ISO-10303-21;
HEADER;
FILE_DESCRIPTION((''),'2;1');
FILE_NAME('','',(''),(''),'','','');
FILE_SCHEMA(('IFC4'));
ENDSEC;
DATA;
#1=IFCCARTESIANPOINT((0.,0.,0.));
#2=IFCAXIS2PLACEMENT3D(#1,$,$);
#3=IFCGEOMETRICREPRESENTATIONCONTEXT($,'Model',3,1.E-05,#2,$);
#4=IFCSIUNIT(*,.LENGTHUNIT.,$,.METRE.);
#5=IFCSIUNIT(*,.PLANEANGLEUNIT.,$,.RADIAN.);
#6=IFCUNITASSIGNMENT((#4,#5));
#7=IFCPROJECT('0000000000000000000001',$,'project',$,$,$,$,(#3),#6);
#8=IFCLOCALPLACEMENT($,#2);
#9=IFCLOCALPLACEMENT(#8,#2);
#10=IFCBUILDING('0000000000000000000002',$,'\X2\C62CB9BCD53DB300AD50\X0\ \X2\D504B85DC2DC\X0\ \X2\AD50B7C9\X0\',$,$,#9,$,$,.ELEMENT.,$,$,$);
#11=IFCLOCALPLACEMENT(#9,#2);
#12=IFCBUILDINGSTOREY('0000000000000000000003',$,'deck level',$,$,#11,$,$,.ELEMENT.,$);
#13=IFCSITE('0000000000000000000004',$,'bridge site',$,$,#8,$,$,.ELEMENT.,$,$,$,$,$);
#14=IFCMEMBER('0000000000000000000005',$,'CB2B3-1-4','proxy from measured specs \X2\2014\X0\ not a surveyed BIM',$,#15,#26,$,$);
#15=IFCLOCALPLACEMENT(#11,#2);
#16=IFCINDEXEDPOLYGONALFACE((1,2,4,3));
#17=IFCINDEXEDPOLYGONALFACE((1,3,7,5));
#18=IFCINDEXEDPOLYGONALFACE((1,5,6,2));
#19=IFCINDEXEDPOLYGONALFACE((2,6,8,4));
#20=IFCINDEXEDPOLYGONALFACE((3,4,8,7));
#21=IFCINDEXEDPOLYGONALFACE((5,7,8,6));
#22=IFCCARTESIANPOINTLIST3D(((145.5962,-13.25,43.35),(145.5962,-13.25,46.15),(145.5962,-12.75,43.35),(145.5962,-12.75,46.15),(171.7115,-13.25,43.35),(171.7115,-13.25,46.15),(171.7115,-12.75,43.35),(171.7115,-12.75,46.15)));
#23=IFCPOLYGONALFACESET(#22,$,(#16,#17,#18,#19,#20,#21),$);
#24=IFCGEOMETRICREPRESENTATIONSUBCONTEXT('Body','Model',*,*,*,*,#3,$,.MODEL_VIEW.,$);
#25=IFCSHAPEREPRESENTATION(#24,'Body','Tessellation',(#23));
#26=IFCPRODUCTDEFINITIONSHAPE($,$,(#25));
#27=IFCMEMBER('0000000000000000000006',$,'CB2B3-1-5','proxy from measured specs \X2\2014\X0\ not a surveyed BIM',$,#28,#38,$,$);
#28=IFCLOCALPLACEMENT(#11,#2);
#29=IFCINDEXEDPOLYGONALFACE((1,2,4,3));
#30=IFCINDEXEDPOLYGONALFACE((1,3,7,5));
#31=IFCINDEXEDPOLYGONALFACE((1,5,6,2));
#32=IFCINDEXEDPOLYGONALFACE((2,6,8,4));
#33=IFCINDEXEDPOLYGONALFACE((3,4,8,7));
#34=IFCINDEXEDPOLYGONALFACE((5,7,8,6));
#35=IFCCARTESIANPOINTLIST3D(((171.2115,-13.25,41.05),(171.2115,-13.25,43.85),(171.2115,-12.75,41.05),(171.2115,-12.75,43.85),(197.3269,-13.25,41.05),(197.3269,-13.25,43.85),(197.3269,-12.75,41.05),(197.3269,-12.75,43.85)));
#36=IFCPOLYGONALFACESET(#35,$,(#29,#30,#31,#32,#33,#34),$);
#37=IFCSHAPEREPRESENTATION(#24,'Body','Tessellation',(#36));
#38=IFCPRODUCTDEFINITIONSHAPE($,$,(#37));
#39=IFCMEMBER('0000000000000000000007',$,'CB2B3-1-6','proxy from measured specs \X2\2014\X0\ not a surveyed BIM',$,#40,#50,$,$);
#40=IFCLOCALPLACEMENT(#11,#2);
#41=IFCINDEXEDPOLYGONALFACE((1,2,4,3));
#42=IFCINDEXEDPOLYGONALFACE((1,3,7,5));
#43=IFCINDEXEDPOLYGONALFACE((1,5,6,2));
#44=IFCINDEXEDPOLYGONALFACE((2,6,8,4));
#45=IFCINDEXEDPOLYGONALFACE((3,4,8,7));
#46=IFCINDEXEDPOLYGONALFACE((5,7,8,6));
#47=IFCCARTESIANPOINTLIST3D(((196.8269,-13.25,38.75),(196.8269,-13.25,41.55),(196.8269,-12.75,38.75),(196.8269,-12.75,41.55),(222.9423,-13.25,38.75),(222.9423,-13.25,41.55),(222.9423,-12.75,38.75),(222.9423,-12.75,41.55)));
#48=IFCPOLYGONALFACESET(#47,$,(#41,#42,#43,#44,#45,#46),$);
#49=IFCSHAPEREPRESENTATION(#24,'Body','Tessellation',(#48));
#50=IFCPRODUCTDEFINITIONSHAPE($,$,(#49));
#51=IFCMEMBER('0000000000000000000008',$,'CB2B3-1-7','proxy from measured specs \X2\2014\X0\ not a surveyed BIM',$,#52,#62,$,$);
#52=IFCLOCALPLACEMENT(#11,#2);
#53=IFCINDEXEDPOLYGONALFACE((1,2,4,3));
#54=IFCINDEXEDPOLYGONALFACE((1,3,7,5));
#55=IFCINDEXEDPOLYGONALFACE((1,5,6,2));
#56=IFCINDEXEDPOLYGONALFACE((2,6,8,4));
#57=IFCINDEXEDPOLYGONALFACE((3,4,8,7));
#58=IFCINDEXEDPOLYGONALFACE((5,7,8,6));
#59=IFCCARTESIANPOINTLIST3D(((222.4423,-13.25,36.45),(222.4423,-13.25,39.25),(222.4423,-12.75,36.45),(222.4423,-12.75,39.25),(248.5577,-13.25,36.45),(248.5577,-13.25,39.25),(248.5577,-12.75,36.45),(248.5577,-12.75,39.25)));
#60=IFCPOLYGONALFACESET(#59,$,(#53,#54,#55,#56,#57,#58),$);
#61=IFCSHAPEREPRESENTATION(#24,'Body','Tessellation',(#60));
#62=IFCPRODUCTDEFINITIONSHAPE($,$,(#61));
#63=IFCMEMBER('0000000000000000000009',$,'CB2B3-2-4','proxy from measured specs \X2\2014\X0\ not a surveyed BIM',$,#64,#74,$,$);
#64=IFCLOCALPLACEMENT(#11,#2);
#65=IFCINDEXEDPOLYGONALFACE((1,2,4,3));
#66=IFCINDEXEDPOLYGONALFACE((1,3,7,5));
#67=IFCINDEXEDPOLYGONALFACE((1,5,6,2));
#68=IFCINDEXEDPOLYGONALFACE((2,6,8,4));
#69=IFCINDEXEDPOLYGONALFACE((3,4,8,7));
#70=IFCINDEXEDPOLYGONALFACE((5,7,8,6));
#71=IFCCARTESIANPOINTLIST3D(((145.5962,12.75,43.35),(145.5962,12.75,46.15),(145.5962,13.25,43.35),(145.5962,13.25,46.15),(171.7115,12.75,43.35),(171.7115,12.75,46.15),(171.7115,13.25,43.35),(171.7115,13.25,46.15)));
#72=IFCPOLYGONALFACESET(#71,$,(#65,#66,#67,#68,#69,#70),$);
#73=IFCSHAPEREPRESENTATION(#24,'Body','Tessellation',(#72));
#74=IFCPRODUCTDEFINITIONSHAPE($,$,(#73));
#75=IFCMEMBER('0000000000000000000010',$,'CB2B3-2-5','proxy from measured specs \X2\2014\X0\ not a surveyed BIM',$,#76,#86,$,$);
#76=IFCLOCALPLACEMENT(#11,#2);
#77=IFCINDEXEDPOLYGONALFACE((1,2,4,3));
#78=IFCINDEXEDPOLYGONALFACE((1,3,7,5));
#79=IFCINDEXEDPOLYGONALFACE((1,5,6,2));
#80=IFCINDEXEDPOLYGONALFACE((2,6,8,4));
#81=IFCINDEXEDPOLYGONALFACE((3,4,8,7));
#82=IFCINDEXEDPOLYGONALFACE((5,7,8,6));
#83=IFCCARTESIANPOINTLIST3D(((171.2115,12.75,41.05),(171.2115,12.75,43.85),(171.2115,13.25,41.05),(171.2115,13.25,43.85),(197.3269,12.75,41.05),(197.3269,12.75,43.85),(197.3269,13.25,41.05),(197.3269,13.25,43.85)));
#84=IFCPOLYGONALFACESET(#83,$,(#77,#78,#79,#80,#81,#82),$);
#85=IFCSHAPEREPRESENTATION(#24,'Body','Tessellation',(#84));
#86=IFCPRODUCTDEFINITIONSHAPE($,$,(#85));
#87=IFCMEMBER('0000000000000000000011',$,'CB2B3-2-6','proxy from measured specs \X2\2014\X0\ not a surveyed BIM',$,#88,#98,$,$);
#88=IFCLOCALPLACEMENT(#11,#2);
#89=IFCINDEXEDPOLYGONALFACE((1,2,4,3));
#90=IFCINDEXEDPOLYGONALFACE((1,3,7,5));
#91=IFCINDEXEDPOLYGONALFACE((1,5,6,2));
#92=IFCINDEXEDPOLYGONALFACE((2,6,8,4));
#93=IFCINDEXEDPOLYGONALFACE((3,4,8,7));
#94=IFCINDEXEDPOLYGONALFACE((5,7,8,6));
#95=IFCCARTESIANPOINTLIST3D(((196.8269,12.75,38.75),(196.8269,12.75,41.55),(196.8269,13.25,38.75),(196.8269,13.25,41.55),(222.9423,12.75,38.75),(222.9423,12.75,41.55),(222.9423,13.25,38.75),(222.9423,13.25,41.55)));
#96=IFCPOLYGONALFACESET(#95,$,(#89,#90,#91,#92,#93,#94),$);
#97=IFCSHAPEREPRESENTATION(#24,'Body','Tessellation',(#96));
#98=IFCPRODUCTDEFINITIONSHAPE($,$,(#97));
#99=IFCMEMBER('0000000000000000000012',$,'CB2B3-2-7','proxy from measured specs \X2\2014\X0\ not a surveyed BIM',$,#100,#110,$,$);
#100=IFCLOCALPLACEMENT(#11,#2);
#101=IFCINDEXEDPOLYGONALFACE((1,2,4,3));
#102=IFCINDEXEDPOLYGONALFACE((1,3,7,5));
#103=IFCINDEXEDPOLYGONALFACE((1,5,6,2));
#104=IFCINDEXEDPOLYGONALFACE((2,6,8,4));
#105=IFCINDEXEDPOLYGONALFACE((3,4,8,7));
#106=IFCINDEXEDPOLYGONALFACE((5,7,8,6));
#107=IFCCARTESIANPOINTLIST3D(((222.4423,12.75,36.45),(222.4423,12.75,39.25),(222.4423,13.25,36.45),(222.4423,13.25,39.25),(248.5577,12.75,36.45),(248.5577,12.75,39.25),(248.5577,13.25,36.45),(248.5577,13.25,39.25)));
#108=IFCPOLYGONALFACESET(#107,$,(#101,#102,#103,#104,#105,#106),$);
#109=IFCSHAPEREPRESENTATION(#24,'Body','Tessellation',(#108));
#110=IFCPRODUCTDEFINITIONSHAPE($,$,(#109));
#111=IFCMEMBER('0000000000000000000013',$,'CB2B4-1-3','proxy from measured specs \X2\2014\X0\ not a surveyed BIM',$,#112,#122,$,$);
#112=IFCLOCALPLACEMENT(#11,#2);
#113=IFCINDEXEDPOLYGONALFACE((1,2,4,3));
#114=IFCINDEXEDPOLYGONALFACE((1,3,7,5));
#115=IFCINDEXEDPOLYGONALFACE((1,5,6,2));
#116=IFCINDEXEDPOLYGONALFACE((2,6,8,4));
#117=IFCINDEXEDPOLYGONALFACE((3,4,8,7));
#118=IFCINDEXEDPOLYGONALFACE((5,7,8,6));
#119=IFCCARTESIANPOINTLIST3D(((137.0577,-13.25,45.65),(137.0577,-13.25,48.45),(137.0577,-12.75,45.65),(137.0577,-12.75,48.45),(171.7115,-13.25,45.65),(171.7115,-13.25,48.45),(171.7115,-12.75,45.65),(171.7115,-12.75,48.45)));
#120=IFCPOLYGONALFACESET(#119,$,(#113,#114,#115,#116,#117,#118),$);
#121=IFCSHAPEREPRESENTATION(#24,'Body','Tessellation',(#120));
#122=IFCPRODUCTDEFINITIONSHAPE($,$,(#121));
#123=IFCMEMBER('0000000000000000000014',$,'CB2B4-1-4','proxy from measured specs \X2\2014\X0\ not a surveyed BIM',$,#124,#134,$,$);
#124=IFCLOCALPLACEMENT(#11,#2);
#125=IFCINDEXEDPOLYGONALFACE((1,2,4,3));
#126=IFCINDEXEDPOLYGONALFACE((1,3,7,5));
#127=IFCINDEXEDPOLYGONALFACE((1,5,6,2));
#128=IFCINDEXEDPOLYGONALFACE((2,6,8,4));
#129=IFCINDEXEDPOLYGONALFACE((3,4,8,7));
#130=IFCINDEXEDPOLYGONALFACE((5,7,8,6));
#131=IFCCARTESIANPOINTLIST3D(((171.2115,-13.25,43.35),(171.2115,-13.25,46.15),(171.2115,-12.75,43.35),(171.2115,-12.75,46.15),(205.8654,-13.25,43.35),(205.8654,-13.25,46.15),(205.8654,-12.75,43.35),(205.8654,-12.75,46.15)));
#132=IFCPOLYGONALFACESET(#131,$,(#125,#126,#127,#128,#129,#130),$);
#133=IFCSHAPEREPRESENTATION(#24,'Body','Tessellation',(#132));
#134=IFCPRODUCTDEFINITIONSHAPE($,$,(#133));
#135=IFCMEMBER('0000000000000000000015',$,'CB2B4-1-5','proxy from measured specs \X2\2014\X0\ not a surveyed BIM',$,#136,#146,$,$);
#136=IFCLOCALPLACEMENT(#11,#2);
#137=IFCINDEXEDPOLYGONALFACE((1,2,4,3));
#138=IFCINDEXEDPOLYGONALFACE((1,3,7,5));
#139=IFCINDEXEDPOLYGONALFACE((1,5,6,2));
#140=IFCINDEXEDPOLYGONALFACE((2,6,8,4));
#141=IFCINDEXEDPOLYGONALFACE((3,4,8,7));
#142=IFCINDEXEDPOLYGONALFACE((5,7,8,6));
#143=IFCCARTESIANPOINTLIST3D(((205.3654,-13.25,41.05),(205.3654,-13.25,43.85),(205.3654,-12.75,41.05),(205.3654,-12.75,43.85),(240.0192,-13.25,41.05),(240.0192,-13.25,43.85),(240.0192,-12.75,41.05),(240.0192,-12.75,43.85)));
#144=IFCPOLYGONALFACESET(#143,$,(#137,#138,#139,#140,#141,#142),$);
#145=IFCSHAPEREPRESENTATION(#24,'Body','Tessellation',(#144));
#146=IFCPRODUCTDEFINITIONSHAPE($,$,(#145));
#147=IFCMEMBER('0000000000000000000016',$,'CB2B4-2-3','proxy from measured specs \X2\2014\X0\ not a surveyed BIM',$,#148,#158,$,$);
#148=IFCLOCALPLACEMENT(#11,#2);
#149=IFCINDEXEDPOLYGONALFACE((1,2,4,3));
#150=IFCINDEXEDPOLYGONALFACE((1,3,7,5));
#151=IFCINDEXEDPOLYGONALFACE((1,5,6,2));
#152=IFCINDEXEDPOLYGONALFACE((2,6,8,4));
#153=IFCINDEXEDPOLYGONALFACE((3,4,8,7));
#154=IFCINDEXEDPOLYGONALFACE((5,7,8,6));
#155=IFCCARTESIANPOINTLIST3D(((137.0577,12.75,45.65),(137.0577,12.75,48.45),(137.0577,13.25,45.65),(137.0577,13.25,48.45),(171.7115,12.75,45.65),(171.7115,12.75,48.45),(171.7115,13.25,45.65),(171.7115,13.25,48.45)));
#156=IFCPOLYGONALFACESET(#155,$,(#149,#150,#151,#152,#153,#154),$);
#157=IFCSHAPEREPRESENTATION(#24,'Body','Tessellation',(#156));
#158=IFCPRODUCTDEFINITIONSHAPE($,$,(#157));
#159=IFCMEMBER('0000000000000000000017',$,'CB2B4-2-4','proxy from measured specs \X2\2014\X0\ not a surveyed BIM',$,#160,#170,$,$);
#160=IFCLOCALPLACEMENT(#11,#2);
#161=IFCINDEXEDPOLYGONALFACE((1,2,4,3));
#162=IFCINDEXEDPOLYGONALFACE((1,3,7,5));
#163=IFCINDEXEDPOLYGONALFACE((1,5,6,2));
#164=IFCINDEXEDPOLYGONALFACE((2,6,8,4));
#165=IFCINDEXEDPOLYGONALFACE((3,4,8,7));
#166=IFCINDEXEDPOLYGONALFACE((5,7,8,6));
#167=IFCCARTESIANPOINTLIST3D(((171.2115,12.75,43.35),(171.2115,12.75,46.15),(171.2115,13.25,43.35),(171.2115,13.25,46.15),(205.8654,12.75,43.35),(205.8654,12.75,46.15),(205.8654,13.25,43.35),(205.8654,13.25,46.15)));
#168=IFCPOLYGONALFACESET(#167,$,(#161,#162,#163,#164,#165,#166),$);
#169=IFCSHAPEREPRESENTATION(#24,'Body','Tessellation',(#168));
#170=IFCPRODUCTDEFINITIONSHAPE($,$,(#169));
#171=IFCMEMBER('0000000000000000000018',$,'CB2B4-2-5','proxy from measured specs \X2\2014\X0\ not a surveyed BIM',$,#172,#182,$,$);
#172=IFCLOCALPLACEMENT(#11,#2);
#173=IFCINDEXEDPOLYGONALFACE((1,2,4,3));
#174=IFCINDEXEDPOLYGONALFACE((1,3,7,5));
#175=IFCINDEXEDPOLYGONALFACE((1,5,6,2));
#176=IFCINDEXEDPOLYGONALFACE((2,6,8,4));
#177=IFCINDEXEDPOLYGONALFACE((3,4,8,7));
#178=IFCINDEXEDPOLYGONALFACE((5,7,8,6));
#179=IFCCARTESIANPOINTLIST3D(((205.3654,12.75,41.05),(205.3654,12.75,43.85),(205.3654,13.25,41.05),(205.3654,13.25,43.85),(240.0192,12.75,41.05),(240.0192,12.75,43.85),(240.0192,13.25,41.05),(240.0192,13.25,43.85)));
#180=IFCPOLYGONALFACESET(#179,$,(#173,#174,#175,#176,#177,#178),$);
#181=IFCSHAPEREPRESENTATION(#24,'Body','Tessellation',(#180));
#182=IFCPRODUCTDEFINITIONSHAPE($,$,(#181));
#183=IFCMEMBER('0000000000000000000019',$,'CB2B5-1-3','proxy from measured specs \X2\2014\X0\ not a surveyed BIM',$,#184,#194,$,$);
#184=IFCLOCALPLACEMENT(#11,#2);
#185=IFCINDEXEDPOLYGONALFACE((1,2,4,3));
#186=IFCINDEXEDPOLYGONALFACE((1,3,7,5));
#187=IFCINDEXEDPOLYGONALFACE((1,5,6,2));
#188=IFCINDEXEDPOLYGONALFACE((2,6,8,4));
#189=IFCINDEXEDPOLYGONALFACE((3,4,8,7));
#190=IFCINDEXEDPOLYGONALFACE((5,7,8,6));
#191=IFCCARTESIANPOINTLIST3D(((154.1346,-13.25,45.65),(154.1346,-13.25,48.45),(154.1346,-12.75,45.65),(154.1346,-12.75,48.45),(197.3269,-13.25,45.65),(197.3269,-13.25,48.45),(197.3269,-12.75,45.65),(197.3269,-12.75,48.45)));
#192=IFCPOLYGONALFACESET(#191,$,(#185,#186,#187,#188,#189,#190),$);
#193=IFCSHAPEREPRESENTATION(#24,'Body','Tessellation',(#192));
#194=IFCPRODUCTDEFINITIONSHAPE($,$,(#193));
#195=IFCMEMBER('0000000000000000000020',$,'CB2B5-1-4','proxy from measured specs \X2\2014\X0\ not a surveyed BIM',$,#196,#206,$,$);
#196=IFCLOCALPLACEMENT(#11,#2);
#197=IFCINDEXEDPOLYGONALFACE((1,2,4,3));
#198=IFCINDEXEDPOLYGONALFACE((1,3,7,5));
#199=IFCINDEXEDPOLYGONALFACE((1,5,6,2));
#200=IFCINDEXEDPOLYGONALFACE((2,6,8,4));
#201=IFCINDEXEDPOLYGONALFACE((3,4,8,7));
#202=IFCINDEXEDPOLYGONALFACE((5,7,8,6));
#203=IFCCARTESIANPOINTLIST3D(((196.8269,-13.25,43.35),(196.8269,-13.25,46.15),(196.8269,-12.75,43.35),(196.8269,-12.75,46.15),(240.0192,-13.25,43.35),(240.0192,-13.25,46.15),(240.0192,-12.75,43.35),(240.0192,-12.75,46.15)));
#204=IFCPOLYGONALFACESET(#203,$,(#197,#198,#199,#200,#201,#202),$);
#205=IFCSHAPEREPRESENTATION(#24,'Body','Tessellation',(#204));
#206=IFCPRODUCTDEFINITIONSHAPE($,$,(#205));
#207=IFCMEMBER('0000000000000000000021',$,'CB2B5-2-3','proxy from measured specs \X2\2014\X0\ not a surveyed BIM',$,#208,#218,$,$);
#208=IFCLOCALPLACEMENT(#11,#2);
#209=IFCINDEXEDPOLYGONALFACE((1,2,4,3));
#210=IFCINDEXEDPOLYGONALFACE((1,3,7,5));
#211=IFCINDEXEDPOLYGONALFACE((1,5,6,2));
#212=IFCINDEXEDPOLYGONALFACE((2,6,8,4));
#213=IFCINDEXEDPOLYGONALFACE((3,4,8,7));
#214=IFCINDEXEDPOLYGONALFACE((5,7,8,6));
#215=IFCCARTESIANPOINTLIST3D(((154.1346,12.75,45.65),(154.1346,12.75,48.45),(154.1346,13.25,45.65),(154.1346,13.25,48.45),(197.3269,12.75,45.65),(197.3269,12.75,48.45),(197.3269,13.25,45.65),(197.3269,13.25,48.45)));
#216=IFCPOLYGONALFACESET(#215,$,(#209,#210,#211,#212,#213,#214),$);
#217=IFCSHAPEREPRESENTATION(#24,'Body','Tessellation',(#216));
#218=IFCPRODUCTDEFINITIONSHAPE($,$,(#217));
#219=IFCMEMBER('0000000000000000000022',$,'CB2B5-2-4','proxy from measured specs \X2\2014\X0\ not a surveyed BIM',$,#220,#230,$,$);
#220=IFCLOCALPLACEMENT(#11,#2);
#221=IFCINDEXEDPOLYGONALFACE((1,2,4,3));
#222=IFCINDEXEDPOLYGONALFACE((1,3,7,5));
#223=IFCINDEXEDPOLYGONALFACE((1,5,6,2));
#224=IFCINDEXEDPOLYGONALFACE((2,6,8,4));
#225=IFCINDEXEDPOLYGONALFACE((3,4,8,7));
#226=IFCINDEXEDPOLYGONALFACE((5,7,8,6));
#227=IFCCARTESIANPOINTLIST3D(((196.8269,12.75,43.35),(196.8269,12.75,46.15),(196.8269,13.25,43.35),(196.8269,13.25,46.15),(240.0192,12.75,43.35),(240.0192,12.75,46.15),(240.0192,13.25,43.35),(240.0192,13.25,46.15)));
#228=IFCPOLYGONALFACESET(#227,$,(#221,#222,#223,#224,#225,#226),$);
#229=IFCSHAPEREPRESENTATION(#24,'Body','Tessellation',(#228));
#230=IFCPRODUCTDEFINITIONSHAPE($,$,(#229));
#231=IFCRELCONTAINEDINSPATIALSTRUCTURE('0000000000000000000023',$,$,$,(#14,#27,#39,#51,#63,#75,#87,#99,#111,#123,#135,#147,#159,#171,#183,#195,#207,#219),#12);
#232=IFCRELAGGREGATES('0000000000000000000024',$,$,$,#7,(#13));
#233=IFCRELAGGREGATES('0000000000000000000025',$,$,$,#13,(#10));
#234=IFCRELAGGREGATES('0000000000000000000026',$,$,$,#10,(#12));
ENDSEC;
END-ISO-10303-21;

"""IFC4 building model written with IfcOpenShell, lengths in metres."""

from ifc_helpers import new_model, si_unit, frame, origin, origin_2d, place, context, subcontext, project, spatial, rectangle, extrude, element, save


model = new_model("IFC4")

# Units and contexts
model_context = context("Model", 3, precision=1e-05, world=origin())
body_context = subcontext(model_context, "Body", "Model", "MODEL_VIEW")
ifc_project = project(units=[si_unit("LENGTHUNIT", "METRE"), si_unit("PLANEANGLEUNIT", "RADIAN")], contexts=[model_context])

# Site, building, storey
site_placement = place(None, origin())
site = spatial("IfcSite", under=ifc_project, at=site_placement, Name="bridge site", CompositionType="ELEMENT")
building_placement = place(site_placement, origin())
building = spatial("IfcBuilding", under=site, at=building_placement, Name="올림픽대교 프록시 교량", CompositionType="ELEMENT")
storey_placement = place(building_placement, origin())
storey = spatial("IfcBuildingStorey", under=building, at=storey_placement, Name="deck level", CompositionType="ELEMENT")

# Members
member_1_placement = place(storey_placement, frame((158.6538, -13.0, 43.35)))
element("IfcMember", 1, at=member_1_placement, inside=storey, Name="CB2B3-1-4", Description="proxy from measured specs — not a surveyed BIM", context=body_context, shape_type="SweptSolid", body=[
    extrude(rectangle(XDim=26.1154, YDim=0.5, at=origin_2d()), origin(), (0.0, 0.0, 1.0), 2.8),
])
for number, where, name in (
    (2, (184.2692, -13.0, 41.05), "CB2B3-1-5"),
    (3, (209.8846, -13.0, 38.75), "CB2B3-1-6"),
    (4, (235.5, -13.0, 36.45), "CB2B3-1-7"),
):
    element("IfcMember", number, at=place(storey_placement, frame(where)), inside=storey, Name=name, Description="proxy from measured specs — not a surveyed BIM", context=body_context, shape_type="SweptSolid", body=[
        extrude(rectangle(XDim=26.1154, YDim=0.5, at=origin_2d()), origin(), (0.0, 0.0, 1.0), 2.8),
    ])
member_2_placement = place(storey_placement, frame((158.6538, 13.0, 43.35)))
element("IfcMember", 5, at=member_2_placement, inside=storey, Name="CB2B3-2-4", Description="proxy from measured specs — not a surveyed BIM", context=body_context, shape_type="SweptSolid", body=[
    extrude(rectangle(XDim=26.1154, YDim=0.5, at=origin_2d()), origin(), (0.0, 0.0, 1.0), 2.8),
])
for number, where, name in (
    (6, (184.2692, 13.0, 41.05), "CB2B3-2-5"),
    (7, (209.8846, 13.0, 38.75), "CB2B3-2-6"),
    (8, (235.5, 13.0, 36.45), "CB2B3-2-7"),
):
    element("IfcMember", number, at=place(storey_placement, frame(where)), inside=storey, Name=name, Description="proxy from measured specs — not a surveyed BIM", context=body_context, shape_type="SweptSolid", body=[
        extrude(rectangle(XDim=26.1154, YDim=0.5, at=origin_2d()), origin(), (0.0, 0.0, 1.0), 2.8),
    ])
member_3_placement = place(storey_placement, frame((154.3846, -13.0, 45.65)))
element("IfcMember", 9, at=member_3_placement, inside=storey, Name="CB2B4-1-3", Description="proxy from measured specs — not a surveyed BIM", context=body_context, shape_type="SweptSolid", body=[
    extrude(rectangle(XDim=34.6538, YDim=0.5, at=origin_2d()), origin(), (0.0, 0.0, 1.0), 2.8),
])
member_4_placement = place(storey_placement, frame((188.5385, -13.0, 43.35)))
element("IfcMember", 10, at=member_4_placement, inside=storey, Name="CB2B4-1-4", Description="proxy from measured specs — not a surveyed BIM", context=body_context, shape_type="SweptSolid", body=[
    extrude(rectangle(XDim=34.6538, YDim=0.5, at=origin_2d()), origin(), (0.0, 0.0, 1.0), 2.8),
])
member_5_placement = place(storey_placement, frame((222.6923, -13.0, 41.05)))
element("IfcMember", 11, at=member_5_placement, inside=storey, Name="CB2B4-1-5", Description="proxy from measured specs — not a surveyed BIM", context=body_context, shape_type="SweptSolid", body=[
    extrude(rectangle(XDim=34.6538, YDim=0.5, at=origin_2d()), origin(), (0.0, 0.0, 1.0), 2.8),
])
member_6_placement = place(storey_placement, frame((154.3846, 13.0, 45.65)))
element("IfcMember", 12, at=member_6_placement, inside=storey, Name="CB2B4-2-3", Description="proxy from measured specs — not a surveyed BIM", context=body_context, shape_type="SweptSolid", body=[
    extrude(rectangle(XDim=34.6538, YDim=0.5, at=origin_2d()), origin(), (0.0, 0.0, 1.0), 2.8),
])
member_7_placement = place(storey_placement, frame((188.5385, 13.0, 43.35)))
element("IfcMember", 13, at=member_7_placement, inside=storey, Name="CB2B4-2-4", Description="proxy from measured specs — not a surveyed BIM", context=body_context, shape_type="SweptSolid", body=[
    extrude(rectangle(XDim=34.6538, YDim=0.5, at=origin_2d()), origin(), (0.0, 0.0, 1.0), 2.8),
])
member_8_placement = place(storey_placement, frame((222.6923, 13.0, 41.05)))
element("IfcMember", 14, at=member_8_placement, inside=storey, Name="CB2B4-2-5", Description="proxy from measured specs — not a surveyed BIM", context=body_context, shape_type="SweptSolid", body=[
    extrude(rectangle(XDim=34.6538, YDim=0.5, at=origin_2d()), origin(), (0.0, 0.0, 1.0), 2.8),
])
member_9_placement = place(storey_placement, frame((175.7308, -13.0, 45.65)))
element("IfcMember", 15, at=member_9_placement, inside=storey, Name="CB2B5-1-3", Description="proxy from measured specs — not a surveyed BIM", context=body_context, shape_type="SweptSolid", body=[
    extrude(rectangle(XDim=43.1923, YDim=0.5, at=origin_2d()), origin(), (0.0, 0.0, 1.0), 2.8),
])
member_10_placement = place(storey_placement, frame((218.4231, -13.0, 43.35)))
element("IfcMember", 16, at=member_10_placement, inside=storey, Name="CB2B5-1-4", Description="proxy from measured specs — not a surveyed BIM", context=body_context, shape_type="SweptSolid", body=[
    extrude(rectangle(XDim=43.1923, YDim=0.5, at=origin_2d()), origin(), (0.0, 0.0, 1.0), 2.8),
])
member_11_placement = place(storey_placement, frame((175.7308, 13.0, 45.65)))
element("IfcMember", 17, at=member_11_placement, inside=storey, Name="CB2B5-2-3", Description="proxy from measured specs — not a surveyed BIM", context=body_context, shape_type="SweptSolid", body=[
    extrude(rectangle(XDim=43.1923, YDim=0.5, at=origin_2d()), origin(), (0.0, 0.0, 1.0), 2.8),
])
member_12_placement = place(storey_placement, frame((218.4231, 13.0, 43.35)))
element("IfcMember", 18, at=member_12_placement, inside=storey, Name="CB2B5-2-4", Description="proxy from measured specs — not a surveyed BIM", context=body_context, shape_type="SweptSolid", body=[
    extrude(rectangle(XDim=43.1923, YDim=0.5, at=origin_2d()), origin(), (0.0, 0.0, 1.0), 2.8),
])

save(model, "model.ifc")
